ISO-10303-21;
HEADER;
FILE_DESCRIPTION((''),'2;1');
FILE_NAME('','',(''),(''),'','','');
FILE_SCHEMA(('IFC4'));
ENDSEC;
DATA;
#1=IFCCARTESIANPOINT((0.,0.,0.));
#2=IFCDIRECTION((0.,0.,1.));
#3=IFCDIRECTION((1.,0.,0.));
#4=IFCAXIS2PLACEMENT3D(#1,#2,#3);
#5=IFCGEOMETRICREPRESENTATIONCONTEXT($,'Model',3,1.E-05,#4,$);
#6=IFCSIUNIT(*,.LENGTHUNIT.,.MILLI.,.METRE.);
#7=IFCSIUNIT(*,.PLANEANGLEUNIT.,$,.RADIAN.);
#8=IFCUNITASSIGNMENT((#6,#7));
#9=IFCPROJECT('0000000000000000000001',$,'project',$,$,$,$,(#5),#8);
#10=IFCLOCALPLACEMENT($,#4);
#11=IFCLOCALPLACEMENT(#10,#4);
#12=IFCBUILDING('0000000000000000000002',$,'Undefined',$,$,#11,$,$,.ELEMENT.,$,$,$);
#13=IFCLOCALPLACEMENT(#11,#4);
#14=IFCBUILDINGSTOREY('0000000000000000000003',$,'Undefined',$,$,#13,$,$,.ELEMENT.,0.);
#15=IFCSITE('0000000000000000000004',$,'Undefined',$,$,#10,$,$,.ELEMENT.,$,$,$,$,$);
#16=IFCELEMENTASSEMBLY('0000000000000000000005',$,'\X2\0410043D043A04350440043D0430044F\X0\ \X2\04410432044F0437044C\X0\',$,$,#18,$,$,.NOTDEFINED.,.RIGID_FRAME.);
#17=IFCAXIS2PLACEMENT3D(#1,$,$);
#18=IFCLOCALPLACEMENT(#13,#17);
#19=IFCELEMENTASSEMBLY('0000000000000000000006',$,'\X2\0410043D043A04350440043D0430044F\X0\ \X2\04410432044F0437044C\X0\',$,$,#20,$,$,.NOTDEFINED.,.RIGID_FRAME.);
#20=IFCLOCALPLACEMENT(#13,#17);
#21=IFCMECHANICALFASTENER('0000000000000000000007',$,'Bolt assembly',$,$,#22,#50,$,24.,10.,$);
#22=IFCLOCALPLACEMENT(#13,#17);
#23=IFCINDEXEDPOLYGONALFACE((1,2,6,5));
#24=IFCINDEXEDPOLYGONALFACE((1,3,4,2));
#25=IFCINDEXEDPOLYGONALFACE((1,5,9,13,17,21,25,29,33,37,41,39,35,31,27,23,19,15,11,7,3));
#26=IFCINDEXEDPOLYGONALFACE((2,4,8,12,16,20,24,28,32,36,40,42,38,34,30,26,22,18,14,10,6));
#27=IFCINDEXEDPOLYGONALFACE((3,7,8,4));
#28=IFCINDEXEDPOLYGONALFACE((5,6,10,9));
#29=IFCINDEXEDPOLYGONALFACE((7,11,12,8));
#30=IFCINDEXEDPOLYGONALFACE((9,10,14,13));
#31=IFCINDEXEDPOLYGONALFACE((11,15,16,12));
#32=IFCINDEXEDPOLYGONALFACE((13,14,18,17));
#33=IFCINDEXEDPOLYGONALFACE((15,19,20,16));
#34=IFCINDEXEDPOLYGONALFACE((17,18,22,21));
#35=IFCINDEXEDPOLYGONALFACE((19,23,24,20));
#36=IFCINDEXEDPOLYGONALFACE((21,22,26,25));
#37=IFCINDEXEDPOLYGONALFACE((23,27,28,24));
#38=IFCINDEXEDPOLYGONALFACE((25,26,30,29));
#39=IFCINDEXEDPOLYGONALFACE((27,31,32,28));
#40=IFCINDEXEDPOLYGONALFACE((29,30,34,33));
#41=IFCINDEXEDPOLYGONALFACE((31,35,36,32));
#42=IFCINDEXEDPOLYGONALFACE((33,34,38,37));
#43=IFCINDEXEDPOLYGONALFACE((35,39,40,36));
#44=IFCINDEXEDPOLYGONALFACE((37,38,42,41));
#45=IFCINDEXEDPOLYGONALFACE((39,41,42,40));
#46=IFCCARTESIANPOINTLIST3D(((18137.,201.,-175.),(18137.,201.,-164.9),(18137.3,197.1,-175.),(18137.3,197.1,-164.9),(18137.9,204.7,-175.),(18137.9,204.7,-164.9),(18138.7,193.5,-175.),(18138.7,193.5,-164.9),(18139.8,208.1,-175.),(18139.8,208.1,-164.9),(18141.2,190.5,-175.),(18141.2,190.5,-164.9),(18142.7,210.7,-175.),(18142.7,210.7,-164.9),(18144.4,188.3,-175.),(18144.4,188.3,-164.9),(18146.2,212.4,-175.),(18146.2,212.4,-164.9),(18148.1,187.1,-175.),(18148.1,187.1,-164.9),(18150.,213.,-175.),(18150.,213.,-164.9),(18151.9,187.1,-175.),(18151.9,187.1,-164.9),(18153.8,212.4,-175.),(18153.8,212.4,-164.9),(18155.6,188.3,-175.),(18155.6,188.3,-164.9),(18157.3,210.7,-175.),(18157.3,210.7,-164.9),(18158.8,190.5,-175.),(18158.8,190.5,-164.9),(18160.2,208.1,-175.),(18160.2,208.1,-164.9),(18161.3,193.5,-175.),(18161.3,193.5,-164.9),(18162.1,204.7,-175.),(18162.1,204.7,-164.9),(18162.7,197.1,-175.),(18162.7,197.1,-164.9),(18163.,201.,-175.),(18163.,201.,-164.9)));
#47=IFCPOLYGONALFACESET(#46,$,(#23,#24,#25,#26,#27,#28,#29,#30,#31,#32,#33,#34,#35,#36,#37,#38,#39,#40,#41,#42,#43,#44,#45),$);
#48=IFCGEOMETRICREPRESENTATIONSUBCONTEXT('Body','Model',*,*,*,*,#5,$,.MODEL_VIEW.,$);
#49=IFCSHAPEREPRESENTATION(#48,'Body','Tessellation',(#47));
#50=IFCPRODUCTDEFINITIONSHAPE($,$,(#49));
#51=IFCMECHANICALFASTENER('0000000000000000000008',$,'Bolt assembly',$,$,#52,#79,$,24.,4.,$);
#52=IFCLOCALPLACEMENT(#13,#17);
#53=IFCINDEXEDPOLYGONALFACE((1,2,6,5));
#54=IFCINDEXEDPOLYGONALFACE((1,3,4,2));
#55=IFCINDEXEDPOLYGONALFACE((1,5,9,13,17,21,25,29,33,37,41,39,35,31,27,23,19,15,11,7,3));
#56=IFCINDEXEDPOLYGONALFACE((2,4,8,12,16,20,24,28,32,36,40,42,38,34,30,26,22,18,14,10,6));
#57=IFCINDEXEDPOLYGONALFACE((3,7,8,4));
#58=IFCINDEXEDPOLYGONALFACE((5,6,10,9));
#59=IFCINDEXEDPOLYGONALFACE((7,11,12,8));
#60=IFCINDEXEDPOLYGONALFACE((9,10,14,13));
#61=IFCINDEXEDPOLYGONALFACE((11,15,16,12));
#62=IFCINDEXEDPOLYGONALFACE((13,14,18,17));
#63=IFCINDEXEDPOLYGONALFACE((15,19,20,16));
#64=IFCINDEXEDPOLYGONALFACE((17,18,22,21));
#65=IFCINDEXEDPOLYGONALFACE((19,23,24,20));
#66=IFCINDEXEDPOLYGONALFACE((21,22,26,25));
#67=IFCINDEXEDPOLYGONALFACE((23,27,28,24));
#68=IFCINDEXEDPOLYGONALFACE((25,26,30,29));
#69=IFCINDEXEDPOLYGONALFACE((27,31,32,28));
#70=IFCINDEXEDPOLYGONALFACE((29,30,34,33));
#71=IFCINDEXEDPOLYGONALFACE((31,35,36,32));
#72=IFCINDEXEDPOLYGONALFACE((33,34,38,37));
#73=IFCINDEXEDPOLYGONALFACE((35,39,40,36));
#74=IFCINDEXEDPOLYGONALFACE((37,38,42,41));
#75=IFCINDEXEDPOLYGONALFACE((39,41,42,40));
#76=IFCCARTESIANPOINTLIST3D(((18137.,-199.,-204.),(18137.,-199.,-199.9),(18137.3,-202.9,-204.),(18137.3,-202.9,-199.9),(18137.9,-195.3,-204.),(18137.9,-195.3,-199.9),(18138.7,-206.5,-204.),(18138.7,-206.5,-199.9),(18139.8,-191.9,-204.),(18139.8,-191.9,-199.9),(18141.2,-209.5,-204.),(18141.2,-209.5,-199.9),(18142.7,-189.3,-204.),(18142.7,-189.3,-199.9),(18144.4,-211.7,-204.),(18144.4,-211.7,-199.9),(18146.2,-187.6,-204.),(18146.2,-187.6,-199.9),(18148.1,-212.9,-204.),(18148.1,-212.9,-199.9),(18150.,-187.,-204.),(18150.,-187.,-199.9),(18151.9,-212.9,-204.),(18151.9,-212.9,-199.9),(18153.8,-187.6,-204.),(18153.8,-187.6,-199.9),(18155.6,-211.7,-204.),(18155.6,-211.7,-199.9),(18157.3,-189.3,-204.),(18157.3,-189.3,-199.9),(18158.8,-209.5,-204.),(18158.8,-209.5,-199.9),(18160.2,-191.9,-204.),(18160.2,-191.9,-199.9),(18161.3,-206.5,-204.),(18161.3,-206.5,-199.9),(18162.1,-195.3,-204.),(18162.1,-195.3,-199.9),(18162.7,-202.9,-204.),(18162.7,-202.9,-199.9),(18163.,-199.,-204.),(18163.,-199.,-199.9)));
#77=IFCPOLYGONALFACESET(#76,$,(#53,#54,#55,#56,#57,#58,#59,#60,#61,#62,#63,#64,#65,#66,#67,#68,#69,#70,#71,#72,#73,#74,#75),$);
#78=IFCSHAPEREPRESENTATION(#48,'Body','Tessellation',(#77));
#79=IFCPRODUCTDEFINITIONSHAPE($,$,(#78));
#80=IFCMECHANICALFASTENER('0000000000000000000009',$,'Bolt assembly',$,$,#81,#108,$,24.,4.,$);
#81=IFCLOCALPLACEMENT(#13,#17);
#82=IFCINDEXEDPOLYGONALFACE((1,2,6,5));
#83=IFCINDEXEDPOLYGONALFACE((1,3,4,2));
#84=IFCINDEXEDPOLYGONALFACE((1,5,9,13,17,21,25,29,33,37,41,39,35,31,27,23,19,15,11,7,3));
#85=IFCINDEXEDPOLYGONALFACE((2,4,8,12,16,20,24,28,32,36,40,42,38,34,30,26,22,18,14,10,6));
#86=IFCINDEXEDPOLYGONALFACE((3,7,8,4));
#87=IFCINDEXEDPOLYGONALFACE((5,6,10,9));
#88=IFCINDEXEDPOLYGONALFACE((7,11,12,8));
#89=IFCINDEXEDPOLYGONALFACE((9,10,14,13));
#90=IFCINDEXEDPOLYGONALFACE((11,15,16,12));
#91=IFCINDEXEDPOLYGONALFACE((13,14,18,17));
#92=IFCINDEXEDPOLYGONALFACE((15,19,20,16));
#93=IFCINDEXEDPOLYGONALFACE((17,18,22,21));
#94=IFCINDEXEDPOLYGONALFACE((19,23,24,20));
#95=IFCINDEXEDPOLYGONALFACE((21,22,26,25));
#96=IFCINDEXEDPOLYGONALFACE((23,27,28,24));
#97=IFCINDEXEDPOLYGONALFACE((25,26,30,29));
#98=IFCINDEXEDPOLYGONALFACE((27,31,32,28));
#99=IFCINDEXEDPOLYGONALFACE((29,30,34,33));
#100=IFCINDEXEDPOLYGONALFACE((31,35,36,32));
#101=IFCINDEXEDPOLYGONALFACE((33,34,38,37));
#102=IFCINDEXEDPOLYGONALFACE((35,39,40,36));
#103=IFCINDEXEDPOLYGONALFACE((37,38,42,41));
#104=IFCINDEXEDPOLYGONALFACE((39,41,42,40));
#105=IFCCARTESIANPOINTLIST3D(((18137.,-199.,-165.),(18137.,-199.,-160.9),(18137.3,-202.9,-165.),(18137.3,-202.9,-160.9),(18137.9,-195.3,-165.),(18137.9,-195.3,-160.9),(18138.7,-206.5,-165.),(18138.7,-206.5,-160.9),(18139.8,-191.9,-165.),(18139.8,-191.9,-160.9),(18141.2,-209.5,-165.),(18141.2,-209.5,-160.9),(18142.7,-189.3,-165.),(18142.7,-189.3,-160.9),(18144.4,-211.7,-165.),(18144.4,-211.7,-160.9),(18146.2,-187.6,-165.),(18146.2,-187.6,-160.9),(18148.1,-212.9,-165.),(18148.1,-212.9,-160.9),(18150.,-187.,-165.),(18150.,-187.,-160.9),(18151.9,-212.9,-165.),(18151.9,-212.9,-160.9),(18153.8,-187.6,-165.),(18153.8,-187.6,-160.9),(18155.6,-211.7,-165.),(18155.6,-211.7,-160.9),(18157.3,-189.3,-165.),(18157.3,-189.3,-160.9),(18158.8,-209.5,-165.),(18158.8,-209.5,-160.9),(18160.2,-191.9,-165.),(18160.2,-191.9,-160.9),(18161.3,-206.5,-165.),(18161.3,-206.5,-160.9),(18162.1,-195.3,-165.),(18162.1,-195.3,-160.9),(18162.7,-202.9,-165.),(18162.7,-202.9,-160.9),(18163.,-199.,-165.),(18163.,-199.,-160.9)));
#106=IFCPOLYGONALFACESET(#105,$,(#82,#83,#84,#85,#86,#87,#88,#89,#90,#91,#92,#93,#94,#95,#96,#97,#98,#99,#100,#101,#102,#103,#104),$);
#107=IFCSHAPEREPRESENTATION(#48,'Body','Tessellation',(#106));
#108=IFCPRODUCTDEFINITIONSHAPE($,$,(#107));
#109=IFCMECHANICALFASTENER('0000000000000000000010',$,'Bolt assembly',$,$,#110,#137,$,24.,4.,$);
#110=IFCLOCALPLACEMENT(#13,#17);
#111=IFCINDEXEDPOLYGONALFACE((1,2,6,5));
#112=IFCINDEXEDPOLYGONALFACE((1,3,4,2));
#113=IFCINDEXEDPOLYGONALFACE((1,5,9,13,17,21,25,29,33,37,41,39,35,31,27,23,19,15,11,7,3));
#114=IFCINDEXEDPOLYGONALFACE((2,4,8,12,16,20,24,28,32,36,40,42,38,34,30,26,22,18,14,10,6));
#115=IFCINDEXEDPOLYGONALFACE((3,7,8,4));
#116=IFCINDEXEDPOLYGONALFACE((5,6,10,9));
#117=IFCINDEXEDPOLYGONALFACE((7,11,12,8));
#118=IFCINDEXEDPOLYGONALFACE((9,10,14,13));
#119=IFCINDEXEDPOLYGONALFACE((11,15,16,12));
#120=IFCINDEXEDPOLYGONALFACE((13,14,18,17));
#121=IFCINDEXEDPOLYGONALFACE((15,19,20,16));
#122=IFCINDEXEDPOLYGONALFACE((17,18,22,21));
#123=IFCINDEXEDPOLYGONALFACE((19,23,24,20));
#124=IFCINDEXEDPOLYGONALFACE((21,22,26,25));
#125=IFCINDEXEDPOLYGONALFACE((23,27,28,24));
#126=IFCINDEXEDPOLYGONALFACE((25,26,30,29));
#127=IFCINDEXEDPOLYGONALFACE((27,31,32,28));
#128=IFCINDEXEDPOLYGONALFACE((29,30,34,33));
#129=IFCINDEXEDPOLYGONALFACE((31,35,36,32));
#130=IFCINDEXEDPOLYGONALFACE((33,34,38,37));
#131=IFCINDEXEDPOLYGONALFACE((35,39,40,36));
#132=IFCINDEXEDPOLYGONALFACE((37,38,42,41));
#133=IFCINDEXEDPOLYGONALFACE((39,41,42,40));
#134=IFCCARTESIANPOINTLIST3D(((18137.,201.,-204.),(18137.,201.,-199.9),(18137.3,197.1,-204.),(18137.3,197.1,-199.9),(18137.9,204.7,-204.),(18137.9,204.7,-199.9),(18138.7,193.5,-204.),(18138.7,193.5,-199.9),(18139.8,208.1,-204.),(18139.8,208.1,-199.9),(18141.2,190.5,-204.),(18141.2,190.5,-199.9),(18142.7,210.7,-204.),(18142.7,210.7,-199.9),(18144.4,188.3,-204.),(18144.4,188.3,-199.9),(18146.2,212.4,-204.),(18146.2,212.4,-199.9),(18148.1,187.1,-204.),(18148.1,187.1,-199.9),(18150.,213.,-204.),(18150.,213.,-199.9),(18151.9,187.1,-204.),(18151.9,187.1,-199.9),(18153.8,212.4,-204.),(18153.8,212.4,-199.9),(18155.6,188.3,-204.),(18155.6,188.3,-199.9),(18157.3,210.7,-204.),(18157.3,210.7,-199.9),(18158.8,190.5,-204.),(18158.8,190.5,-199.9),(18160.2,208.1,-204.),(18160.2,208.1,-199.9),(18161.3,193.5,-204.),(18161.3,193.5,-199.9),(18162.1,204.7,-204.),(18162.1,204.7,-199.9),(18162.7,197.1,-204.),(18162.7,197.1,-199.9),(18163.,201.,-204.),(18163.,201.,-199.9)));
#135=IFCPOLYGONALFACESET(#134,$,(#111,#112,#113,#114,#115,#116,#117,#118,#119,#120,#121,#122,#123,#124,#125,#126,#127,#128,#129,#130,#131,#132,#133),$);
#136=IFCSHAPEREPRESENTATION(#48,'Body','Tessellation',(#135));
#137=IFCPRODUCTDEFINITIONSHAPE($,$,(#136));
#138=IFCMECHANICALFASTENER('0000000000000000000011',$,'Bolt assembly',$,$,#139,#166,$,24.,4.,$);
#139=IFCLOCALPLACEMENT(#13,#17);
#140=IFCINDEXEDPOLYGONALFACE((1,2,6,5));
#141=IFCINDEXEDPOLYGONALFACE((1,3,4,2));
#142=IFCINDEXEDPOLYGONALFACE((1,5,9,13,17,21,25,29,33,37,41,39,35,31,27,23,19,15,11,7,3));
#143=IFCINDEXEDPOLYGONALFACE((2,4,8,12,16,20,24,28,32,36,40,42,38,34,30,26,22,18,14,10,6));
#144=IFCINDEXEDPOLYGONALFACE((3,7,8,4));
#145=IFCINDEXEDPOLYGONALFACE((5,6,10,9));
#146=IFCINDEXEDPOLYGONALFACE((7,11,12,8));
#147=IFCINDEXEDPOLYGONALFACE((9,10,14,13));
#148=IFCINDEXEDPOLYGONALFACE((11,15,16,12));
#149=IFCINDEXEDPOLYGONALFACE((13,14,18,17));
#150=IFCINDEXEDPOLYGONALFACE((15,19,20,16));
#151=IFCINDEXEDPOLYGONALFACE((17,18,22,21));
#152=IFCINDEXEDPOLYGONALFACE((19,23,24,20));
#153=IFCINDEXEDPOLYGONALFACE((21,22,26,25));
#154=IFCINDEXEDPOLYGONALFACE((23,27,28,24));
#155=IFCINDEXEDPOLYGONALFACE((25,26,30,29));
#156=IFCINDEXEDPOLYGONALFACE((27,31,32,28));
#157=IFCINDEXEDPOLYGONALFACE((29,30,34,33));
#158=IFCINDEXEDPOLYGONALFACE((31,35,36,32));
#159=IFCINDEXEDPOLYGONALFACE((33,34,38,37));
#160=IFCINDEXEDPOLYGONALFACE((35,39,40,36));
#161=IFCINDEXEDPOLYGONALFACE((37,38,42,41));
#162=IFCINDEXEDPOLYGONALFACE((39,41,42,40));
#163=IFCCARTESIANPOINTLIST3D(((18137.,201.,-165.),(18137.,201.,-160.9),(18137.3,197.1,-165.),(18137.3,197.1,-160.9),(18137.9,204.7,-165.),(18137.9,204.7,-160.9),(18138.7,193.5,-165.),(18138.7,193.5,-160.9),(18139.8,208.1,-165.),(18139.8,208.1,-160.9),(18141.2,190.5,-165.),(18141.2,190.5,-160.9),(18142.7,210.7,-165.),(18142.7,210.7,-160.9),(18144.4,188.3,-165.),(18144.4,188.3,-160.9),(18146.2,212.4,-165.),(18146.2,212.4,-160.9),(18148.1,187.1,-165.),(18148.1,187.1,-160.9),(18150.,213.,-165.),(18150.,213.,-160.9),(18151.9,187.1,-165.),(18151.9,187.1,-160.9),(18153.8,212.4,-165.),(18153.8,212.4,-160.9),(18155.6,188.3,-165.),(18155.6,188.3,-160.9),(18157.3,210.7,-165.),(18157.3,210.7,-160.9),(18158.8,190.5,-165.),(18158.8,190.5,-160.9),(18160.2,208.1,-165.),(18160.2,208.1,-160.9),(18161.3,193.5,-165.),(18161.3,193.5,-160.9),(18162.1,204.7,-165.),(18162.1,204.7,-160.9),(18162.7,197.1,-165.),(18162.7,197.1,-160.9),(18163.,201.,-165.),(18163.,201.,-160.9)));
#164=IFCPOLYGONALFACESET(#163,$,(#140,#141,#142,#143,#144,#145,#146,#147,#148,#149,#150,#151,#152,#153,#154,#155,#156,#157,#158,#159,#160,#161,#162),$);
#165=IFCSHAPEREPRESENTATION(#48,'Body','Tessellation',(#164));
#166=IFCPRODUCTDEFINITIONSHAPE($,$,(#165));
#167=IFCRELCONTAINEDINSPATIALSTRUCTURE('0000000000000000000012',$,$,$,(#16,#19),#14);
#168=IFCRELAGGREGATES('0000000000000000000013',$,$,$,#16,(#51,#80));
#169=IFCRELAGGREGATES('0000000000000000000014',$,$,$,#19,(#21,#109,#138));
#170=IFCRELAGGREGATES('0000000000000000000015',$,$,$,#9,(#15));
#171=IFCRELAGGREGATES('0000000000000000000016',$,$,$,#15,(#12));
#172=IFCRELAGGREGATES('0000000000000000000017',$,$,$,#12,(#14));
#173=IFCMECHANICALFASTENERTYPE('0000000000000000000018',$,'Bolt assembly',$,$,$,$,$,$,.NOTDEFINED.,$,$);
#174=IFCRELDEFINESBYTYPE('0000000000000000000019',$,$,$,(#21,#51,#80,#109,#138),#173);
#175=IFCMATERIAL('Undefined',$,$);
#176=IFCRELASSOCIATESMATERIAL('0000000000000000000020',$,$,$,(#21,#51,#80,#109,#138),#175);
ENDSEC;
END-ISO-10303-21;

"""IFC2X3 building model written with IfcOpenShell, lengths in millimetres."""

from ifc_helpers import new_model, si_unit, frame, origin_with_axes, origin_2d_with_axis, place, context, subcontext, project, spatial, circle, extrude, source, transform, mapped, material, type_object, element, aggregate, save


model = new_model("IFC2X3")

# Units and contexts
model_context = context("Model", 3, precision=1e-05, world=origin_with_axes())
body_context = subcontext(model_context, "Body", "Model", "MODEL_VIEW")
ifc_project = project(units=[si_unit("LENGTHUNIT", "METRE", prefix="MILLI"), si_unit("PLANEANGLEUNIT", "RADIAN")], contexts=[model_context])

# Site, building, storey
site_placement = place(None, origin_with_axes())
site = spatial("IfcSite", under=ifc_project, at=site_placement, Name="Undefined", CompositionType="ELEMENT")
building_placement = place(site_placement, origin_with_axes())
building = spatial("IfcBuilding", under=site, at=building_placement, Name="Undefined", CompositionType="ELEMENT")
storey_placement = place(building_placement, origin_with_axes())
storey = spatial("IfcBuildingStorey", under=building, at=storey_placement, Name="Undefined", CompositionType="ELEMENT", Elevation=0.0)

# Element assemblies
assembly_1_placement = place(storey_placement, origin_with_axes())
assembly_1 = element("IfcElementAssembly", 1, at=assembly_1_placement, inside=storey, Name="Анкерная связь", AssemblyPlace="NOTDEFINED", PredefinedType="RIGID_FRAME")
assembly_2_placement = place(storey_placement, origin_with_axes())
assembly_2 = element("IfcElementAssembly", 2, at=assembly_2_placement, inside=storey, Name="Анкерная связь", AssemblyPlace="NOTDEFINED", PredefinedType="RIGID_FRAME")

# Mechanical fasteners
ifc_material_1 = material(Name="Undefined")
mechanical_fastener_type = type_object("IfcMechanicalFastenerType", Name="Bolt assembly")
shared_shape_1 = source(origin_with_axes(), body_context, "Body", "SweptSolid", [
    extrude(circle(Radius=13.0, at=origin_2d_with_axis()), frame((0.0, 0.0, 0.0), z_axis=(0.0, 1.0, 0.0), x_axis=(1.0, 0.0, 0.0)), (0.0, 0.0, 1.0), 10.1),
])
mechanical_fastener_1_placement = place(assembly_2_placement, frame((18150.0, 200.0, -175.0), z_axis=(1.0, 0.0, 0.0), x_axis=(0.0, 1.0, 0.0)))
mechanical_fastener_1 = element("IfcMechanicalFastener", 3, at=mechanical_fastener_1_placement, type_object=mechanical_fastener_type, material=ifc_material_1, Name="Bolt assembly", NominalDiameter=24.0, NominalLength=10.0, context=body_context, shape_type="MappedRepresentation", body=[
    mapped(shared_shape_1, transform((0.0, 0.0, 0.0))),
])
shared_shape_2 = source(origin_with_axes(), body_context, "Body", "SweptSolid", [
    extrude(circle(Radius=13.0, at=origin_2d_with_axis()), frame((0.0, -4.0, 0.0), z_axis=(0.0, 1.0, 0.0), x_axis=(1.0, 0.0, 0.0)), (0.0, 0.0, 1.0), 4.1),
])
mechanical_fastener_2_placement = place(assembly_1_placement, frame((18150.0, -200.0, -200.0), z_axis=(1.0, 0.0, 0.0), x_axis=(0.0, 1.0, 0.0)))
mechanical_fastener_2 = element("IfcMechanicalFastener", 4, at=mechanical_fastener_2_placement, type_object=mechanical_fastener_type, material=ifc_material_1, Name="Bolt assembly", NominalDiameter=24.0, NominalLength=4.0, context=body_context, shape_type="MappedRepresentation", body=[
    mapped(shared_shape_2, transform((0.0, 0.0, 0.0))),
])
mechanical_fastener_3_placement = place(assembly_1_placement, frame((18150.0, -200.0, -161.0), z_axis=(1.0, 0.0, 0.0), x_axis=(0.0, 1.0, 0.0)))
mechanical_fastener_3 = element("IfcMechanicalFastener", 5, at=mechanical_fastener_3_placement, type_object=mechanical_fastener_type, material=ifc_material_1, Name="Bolt assembly", NominalDiameter=24.0, NominalLength=4.0, context=body_context, shape_type="MappedRepresentation", body=[
    mapped(shared_shape_2, transform((0.0, 0.0, 0.0))),
])
aggregate(assembly_1, [mechanical_fastener_2, mechanical_fastener_3])
mechanical_fastener_4_placement = place(assembly_2_placement, frame((18150.0, 200.0, -200.0), z_axis=(1.0, 0.0, 0.0), x_axis=(0.0, 1.0, 0.0)))
mechanical_fastener_4 = element("IfcMechanicalFastener", 6, at=mechanical_fastener_4_placement, type_object=mechanical_fastener_type, material=ifc_material_1, Name="Bolt assembly", NominalDiameter=24.0, NominalLength=4.0, context=body_context, shape_type="MappedRepresentation", body=[
    mapped(shared_shape_2, transform((0.0, 0.0, 0.0))),
])
mechanical_fastener_5_placement = place(assembly_2_placement, frame((18150.0, 200.0, -161.0), z_axis=(1.0, 0.0, 0.0), x_axis=(0.0, 1.0, 0.0)))
mechanical_fastener_5 = element("IfcMechanicalFastener", 7, at=mechanical_fastener_5_placement, type_object=mechanical_fastener_type, material=ifc_material_1, Name="Bolt assembly", NominalDiameter=24.0, NominalLength=4.0, context=body_context, shape_type="MappedRepresentation", body=[
    mapped(shared_shape_2, transform((0.0, 0.0, 0.0))),
])
aggregate(assembly_2, [mechanical_fastener_1, mechanical_fastener_4, mechanical_fastener_5])

save(model, "model.ifc")
